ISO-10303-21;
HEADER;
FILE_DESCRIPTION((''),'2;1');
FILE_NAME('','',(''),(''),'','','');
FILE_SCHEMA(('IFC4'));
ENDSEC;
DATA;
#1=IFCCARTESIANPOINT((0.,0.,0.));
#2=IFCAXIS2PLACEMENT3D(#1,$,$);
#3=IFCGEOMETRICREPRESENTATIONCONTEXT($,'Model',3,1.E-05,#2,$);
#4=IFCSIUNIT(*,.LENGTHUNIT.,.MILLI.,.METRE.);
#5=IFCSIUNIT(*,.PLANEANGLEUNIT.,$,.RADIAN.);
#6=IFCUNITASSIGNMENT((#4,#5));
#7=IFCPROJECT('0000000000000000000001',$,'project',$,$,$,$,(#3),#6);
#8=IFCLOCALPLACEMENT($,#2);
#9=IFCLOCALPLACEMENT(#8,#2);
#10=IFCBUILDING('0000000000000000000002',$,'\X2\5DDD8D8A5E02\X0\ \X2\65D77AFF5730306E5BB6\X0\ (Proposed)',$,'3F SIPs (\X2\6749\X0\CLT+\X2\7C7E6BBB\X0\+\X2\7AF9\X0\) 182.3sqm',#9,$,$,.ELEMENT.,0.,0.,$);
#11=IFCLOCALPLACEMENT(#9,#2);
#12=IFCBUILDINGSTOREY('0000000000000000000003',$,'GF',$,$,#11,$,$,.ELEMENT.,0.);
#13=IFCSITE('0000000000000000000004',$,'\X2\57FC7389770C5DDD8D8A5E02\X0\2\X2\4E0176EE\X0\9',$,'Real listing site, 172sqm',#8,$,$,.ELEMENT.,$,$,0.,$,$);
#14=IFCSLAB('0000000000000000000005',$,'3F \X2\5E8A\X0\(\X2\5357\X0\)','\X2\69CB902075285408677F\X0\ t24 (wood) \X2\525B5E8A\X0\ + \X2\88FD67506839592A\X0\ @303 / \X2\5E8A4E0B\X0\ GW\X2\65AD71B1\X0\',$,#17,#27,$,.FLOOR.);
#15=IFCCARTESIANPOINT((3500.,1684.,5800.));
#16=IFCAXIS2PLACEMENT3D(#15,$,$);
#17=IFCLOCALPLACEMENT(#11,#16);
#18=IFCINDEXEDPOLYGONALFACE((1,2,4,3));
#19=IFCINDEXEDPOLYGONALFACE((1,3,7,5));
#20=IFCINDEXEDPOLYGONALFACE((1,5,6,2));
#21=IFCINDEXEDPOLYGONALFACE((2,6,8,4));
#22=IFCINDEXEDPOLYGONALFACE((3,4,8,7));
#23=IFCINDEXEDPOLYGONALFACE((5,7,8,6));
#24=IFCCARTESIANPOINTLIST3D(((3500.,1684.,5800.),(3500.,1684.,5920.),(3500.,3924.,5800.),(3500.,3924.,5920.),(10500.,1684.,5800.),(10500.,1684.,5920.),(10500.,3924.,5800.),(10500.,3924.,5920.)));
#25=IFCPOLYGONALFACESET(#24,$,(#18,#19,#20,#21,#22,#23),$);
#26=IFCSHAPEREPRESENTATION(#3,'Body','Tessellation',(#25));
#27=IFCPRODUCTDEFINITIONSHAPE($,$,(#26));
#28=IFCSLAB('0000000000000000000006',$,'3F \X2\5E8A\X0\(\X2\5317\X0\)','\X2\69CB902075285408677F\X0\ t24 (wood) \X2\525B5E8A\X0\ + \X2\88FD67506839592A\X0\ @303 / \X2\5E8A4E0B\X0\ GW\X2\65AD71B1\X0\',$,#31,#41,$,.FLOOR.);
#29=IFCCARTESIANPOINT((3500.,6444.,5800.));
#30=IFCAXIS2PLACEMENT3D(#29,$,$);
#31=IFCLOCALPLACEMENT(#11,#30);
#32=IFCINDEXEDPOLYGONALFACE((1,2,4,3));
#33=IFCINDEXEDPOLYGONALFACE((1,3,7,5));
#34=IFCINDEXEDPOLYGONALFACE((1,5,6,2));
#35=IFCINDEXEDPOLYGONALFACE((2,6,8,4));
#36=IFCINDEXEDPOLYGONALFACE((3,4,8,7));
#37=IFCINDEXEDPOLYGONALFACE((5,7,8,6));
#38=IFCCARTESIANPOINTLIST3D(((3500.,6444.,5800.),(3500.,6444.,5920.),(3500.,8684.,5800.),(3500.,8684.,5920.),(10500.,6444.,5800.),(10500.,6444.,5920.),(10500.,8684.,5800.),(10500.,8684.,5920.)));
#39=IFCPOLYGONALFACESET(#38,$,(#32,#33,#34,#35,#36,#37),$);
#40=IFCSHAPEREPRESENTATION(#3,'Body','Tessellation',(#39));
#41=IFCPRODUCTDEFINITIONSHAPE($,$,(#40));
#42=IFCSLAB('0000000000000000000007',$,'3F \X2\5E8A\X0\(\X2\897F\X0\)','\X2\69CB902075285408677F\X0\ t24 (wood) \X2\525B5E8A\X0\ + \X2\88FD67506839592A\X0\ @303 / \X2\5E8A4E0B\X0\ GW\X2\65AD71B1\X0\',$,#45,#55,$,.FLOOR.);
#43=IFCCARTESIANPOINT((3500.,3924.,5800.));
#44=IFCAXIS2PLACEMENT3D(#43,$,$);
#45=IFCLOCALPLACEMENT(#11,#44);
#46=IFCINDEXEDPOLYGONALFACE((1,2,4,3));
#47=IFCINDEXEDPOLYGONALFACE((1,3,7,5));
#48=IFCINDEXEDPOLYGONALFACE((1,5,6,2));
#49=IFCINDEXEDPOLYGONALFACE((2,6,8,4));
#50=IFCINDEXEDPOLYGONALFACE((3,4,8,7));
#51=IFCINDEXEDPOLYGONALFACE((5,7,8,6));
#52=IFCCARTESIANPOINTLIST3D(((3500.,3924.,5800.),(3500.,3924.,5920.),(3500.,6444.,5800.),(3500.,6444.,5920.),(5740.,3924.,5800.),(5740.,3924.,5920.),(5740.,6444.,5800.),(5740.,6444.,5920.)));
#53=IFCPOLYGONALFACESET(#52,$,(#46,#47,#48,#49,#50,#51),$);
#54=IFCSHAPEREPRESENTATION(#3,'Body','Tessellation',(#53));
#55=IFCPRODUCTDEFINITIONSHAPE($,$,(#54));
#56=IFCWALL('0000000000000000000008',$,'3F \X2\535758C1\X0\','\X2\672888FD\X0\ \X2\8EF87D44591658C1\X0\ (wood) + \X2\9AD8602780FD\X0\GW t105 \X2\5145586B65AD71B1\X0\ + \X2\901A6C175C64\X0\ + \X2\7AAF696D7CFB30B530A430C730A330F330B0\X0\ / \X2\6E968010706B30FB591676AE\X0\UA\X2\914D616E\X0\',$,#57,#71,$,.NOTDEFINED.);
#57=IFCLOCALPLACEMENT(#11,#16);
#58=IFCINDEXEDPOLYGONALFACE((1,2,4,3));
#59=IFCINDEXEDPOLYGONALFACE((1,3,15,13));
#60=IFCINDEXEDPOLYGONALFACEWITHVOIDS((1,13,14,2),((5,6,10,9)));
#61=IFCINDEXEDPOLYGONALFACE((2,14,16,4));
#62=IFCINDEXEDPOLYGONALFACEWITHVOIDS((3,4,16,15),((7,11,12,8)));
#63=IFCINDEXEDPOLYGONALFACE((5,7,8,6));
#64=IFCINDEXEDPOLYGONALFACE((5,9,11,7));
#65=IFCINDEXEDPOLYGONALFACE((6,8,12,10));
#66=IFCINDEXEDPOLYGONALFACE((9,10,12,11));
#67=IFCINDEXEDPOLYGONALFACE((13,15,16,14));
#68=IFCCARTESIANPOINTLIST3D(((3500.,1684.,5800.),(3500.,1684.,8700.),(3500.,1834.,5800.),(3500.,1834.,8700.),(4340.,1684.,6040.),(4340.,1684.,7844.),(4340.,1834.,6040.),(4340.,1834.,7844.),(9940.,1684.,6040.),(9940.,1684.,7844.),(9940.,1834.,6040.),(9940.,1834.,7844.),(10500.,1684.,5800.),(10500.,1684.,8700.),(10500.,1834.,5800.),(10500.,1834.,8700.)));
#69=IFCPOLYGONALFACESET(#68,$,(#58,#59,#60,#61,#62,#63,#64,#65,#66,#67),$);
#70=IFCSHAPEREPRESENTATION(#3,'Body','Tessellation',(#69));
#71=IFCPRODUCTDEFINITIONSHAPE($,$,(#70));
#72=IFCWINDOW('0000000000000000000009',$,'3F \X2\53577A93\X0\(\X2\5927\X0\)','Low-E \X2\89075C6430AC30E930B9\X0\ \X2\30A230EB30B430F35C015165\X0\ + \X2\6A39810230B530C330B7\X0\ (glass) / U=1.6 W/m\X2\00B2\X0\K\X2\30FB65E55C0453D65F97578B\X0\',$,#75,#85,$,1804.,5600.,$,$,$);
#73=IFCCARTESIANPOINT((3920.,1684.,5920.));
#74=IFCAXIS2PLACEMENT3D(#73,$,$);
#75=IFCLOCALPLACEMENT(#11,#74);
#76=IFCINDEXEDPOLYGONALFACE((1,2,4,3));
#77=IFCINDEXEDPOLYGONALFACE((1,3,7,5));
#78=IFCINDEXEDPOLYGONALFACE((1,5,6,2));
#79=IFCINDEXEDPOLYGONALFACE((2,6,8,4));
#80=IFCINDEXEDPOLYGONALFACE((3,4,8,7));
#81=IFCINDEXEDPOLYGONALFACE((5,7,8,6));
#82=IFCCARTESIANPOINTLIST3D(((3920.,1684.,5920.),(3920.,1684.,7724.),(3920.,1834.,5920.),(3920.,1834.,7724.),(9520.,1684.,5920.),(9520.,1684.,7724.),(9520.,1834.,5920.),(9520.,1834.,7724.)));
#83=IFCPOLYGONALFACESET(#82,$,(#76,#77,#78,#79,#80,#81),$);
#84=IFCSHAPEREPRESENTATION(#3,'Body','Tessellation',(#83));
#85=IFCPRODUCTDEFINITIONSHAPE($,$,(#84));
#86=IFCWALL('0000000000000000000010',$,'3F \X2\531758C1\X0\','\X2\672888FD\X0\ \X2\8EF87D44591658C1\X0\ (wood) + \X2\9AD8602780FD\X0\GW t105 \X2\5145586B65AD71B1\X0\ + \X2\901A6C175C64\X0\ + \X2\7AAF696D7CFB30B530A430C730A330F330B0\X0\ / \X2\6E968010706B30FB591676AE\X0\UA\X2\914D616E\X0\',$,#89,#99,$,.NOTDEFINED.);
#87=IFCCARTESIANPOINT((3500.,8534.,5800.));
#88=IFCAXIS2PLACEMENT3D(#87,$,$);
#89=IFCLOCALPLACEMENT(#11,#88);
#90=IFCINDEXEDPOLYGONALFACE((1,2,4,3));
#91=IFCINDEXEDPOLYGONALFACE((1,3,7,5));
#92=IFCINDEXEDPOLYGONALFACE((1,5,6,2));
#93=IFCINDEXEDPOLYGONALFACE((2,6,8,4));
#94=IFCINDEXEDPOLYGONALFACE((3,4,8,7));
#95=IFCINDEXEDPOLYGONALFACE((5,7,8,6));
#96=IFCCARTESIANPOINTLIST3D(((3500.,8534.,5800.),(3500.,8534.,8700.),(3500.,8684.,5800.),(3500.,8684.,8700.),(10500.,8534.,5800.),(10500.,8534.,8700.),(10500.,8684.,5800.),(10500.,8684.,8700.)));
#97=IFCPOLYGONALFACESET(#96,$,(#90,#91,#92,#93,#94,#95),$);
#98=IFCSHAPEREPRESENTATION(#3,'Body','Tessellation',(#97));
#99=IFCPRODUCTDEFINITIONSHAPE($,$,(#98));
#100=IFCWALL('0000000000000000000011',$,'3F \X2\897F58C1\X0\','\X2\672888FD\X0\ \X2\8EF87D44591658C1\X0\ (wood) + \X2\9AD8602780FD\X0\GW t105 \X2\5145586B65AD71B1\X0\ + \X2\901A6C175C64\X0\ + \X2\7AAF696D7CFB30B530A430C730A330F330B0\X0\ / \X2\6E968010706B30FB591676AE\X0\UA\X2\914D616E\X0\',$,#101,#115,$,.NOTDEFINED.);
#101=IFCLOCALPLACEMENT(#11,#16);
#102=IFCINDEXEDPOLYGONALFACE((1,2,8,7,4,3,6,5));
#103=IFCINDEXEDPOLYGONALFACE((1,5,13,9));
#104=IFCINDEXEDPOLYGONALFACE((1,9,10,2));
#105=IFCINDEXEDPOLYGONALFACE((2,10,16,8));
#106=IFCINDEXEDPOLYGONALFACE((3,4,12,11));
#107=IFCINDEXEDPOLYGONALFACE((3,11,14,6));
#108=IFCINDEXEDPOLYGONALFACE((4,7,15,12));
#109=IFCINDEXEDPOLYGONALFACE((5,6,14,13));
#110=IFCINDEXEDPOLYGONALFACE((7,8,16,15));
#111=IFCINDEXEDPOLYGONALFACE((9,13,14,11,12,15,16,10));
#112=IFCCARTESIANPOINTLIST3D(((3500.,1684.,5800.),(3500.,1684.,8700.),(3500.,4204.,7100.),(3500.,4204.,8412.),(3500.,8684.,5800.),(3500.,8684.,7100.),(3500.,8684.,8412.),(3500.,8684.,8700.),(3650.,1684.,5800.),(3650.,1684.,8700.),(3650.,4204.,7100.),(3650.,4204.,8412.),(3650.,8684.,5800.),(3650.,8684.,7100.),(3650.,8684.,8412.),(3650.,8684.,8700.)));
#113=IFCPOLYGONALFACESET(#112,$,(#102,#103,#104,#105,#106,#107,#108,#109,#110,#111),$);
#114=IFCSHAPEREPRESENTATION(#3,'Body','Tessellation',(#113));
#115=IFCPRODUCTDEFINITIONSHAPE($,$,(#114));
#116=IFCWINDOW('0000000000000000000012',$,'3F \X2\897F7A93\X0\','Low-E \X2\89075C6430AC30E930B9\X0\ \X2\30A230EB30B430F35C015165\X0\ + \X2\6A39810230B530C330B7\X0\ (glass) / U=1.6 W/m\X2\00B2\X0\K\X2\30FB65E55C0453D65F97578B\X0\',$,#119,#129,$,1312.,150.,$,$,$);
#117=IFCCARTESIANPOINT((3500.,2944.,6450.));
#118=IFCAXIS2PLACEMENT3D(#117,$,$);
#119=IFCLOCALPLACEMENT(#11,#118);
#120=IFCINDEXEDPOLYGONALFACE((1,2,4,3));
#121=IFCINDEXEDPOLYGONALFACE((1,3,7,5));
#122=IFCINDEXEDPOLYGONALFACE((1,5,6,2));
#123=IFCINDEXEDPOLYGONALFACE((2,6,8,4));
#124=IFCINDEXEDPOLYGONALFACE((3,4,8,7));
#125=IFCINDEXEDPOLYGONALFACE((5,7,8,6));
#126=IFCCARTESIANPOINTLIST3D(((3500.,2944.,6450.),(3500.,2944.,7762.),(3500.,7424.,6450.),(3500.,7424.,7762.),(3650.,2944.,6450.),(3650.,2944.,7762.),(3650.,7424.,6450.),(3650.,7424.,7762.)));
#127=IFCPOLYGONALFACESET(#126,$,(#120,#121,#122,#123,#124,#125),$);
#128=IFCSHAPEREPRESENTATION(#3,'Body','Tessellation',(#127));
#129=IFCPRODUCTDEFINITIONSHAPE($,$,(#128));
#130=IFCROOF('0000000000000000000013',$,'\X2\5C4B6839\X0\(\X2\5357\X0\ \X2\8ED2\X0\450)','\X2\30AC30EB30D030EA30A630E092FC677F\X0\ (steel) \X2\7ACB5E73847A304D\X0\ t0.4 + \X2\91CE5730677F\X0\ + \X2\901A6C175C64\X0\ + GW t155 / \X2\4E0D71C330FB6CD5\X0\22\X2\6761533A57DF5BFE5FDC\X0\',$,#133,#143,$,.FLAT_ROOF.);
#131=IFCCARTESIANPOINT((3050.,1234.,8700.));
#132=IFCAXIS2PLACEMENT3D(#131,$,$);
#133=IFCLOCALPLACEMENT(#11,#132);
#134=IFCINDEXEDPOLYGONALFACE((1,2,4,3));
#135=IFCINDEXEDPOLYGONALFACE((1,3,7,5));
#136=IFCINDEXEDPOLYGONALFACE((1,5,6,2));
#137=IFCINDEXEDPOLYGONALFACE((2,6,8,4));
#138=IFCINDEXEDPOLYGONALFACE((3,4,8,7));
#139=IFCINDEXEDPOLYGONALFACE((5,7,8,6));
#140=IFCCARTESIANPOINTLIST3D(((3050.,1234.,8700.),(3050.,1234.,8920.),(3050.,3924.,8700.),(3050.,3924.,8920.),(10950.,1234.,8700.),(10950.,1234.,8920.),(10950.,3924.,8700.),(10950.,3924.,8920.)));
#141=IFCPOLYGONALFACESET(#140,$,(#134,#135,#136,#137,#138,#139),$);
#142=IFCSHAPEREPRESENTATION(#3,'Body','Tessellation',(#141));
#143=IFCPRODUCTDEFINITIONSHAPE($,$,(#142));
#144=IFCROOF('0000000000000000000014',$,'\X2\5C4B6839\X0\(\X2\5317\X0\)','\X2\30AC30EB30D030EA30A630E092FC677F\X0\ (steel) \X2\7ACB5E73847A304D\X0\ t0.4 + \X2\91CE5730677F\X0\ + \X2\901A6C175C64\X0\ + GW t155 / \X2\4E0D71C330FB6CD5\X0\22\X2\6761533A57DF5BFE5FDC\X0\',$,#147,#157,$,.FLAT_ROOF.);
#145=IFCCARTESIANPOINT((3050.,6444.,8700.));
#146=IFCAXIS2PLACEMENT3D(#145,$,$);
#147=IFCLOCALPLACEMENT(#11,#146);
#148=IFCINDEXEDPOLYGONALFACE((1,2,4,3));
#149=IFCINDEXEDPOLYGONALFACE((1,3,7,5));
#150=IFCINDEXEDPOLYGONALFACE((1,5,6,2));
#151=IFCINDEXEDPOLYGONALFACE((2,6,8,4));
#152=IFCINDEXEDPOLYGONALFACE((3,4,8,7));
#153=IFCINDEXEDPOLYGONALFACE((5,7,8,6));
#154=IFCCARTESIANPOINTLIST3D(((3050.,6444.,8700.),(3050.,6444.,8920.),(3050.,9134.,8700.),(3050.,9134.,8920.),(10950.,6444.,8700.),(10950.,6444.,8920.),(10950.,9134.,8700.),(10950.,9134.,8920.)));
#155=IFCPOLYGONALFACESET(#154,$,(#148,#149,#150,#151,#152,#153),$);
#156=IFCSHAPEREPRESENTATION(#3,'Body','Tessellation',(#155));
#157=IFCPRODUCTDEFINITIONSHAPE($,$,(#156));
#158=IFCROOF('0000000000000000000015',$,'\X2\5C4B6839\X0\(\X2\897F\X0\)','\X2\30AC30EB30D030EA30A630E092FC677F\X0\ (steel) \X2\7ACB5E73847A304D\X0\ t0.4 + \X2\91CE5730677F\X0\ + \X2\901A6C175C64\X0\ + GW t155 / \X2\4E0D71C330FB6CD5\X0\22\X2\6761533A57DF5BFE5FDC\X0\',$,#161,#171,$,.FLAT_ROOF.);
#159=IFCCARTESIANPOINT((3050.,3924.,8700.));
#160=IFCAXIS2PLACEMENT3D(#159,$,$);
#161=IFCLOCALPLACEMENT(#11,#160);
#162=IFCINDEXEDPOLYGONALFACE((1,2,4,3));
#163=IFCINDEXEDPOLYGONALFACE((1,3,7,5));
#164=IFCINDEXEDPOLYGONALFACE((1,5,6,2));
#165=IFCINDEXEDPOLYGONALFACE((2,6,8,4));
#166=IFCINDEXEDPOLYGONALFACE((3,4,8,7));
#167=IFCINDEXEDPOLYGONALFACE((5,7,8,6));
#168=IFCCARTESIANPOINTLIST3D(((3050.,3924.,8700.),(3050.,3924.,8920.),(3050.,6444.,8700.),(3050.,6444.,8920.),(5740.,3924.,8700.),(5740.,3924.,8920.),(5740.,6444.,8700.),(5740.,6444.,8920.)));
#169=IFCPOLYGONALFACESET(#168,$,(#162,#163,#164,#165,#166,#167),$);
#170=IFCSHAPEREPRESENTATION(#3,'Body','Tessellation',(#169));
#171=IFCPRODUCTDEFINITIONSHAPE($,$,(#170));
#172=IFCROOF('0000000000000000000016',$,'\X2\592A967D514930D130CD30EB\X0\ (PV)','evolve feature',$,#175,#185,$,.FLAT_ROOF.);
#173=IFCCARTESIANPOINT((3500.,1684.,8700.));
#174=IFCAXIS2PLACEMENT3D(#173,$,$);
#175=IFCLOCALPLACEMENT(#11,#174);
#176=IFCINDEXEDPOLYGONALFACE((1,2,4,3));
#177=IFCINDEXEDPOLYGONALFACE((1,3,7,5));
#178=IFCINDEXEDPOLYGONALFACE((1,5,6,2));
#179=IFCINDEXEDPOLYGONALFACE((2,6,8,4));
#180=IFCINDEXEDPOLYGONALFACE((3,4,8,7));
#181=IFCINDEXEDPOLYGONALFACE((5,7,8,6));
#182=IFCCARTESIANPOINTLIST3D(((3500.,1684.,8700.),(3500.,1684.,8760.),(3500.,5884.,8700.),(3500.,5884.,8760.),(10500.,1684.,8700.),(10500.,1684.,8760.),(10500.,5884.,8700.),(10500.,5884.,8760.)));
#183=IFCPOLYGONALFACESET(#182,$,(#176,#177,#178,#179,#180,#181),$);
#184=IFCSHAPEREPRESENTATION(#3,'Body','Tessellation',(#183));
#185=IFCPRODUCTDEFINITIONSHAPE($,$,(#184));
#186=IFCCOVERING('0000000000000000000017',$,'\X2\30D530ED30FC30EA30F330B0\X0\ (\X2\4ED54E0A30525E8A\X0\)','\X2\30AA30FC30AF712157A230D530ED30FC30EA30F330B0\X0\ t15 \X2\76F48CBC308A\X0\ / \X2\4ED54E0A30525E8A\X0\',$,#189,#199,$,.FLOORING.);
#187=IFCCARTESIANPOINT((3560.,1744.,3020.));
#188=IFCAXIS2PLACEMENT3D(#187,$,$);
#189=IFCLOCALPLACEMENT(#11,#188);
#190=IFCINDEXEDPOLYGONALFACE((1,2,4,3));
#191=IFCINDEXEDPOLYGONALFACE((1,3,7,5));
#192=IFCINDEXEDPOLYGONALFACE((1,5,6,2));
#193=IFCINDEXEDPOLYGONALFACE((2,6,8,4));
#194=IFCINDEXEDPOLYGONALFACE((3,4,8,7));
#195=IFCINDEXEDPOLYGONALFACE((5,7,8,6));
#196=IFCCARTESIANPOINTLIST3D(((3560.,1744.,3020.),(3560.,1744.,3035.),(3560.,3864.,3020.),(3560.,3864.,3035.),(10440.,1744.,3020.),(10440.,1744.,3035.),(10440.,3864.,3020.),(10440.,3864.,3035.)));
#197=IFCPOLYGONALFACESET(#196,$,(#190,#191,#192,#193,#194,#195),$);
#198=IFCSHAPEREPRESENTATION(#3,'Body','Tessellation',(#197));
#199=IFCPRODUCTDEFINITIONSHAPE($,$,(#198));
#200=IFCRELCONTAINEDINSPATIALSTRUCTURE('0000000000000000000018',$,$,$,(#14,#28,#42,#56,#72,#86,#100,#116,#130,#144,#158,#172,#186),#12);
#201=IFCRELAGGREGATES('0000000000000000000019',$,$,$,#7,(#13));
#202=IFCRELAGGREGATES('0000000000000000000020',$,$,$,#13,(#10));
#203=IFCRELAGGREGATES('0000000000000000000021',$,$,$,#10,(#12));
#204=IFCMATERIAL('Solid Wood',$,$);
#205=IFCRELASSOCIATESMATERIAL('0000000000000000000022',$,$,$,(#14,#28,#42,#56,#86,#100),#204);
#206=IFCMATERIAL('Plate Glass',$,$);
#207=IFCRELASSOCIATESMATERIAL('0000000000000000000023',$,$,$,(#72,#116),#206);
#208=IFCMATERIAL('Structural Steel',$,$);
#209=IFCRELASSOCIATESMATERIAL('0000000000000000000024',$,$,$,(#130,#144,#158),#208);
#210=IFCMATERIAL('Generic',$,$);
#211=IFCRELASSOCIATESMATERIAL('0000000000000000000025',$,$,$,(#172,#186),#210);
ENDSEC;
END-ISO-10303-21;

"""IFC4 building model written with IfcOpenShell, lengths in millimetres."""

from ifc_helpers import new_model, si_unit, frame, frame_2d, origin, place, context, project, spatial, rectangle, extrude, material, element, fill, save


model = new_model("IFC4")

# Units and contexts
model_context = context("Model", 3, precision=1e-05, world=origin())
ifc_project = project(units=[si_unit("LENGTHUNIT", "METRE", prefix="MILLI"), si_unit("PLANEANGLEUNIT", "RADIAN")], contexts=[model_context])

# Site, building, storey
site_placement = place(None, origin())
site = spatial("IfcSite", under=ifc_project, at=site_placement, Name="埼玉県川越市2丁目9", ObjectType="Real listing site, 172sqm", CompositionType="ELEMENT", RefElevation=0.0)
building_placement = place(site_placement, origin())
building = spatial("IfcBuilding", under=site, at=building_placement, Name="川越市 旗竿地の家 (Proposed)", ObjectType="3F SIPs (杉CLT+籾殻+竹) 182.3sqm", CompositionType="ELEMENT", ElevationOfRefHeight=0.0, ElevationOfTerrain=0.0)
storey_placement = place(building_placement, origin())
storey = spatial("IfcBuildingStorey", under=building, at=storey_placement, Name="GF", CompositionType="ELEMENT", Elevation=0.0)

# Slabs
ifc_material_1 = material(Name="Solid Wood")
slab_1_placement = place(storey_placement, frame((3500.0, 1684.0, 5800.0)))
element("IfcSlab", 1, at=slab_1_placement, inside=storey, material=ifc_material_1, Name="3F 床(南)", Description="構造用合板 t24 (wood) 剛床 + 製材根太 @303 / 床下 GW断熱", PredefinedType="FLOOR", context=model_context, shape_type="SweptSolid", body=[
    extrude(rectangle(XDim=7000.0, YDim=2240.0, at=frame_2d((3500.0, 1120.0))), frame((3500.0, 1684.0, 5800.0)), (0.0, 0.0, 1.0), 120.0),
])
slab_2_placement = place(storey_placement, frame((3500.0, 6444.0, 5800.0)))
element("IfcSlab", 2, at=slab_2_placement, inside=storey, material=ifc_material_1, Name="3F 床(北)", Description="構造用合板 t24 (wood) 剛床 + 製材根太 @303 / 床下 GW断熱", PredefinedType="FLOOR", context=model_context, shape_type="SweptSolid", body=[
    extrude(rectangle(XDim=7000.0, YDim=2240.0, at=frame_2d((3500.0, 1120.0))), frame((3500.0, 6444.0, 5800.0)), (0.0, 0.0, 1.0), 120.0),
])
slab_3_placement = place(storey_placement, frame((3500.0, 3924.0, 5800.0)))
element("IfcSlab", 3, at=slab_3_placement, inside=storey, material=ifc_material_1, Name="3F 床(西)", Description="構造用合板 t24 (wood) 剛床 + 製材根太 @303 / 床下 GW断熱", PredefinedType="FLOOR", context=model_context, shape_type="SweptSolid", body=[
    extrude(rectangle(XDim=2240.0, YDim=2520.0, at=frame_2d((1120.0, 1260.0))), frame((3500.0, 3924.0, 5800.0)), (0.0, 0.0, 1.0), 120.0),
])

# Wall, opening, window
wall_1_placement = place(storey_placement, frame((3500.0, 1684.0, 5800.0)))
wall_1 = element("IfcWall", 4, at=wall_1_placement, inside=storey, material=ifc_material_1, Name="3F 南壁", Description="木製 軸組外壁 (wood) + 高性能GW t105 充填断熱 + 通気層 + 窯業系サイディング / 準耐火・外皮UA配慮", PredefinedType="NOTDEFINED", context=model_context, shape_type="SweptSolid", body=[
    extrude(rectangle(XDim=7000.0, YDim=150.0, at=frame_2d((3500.0, 75.0))), frame((3500.0, 1684.0, 5800.0)), (0.0, 0.0, 1.0), 2900.0),
])
opening_1_placement = place(storey_placement, frame((3920.0, 1684.0, 5920.0)))
opening_1 = element("IfcOpeningElement", 5, at=opening_1_placement, cuts=wall_1, PredefinedType="NOTDEFINED", context=model_context, shape_type="SweptSolid", body=[
    extrude(rectangle(XDim=5600.0, YDim=150.0, at=frame_2d((2800.0, 75.0))), frame((3920.0, 1684.0, 5920.0)), (0.0, 0.0, 1.0), 1804.0),
])
ifc_material_2 = material(Name="Plate Glass")
window_1_placement = place(storey_placement, frame((3920.0, 1684.0, 5920.0)))
window_1 = element("IfcWindow", 6, at=window_1_placement, inside=storey, material=ifc_material_2, Name="3F 南窓(大)", Description="Low-E 複層ガラス アルゴン封入 + 樹脂サッシ (glass) / U=1.6 W/m²K・日射取得型", OverallHeight=1804.0, OverallWidth=5600.0, context=model_context, shape_type="SweptSolid", body=[
    extrude(rectangle(XDim=5600.0, YDim=150.0, at=frame_2d((2800.0, 75.0))), frame((3920.0, 1684.0, 5920.0)), (0.0, 0.0, 1.0), 1804.0),
])
fill(opening_1, window_1)

# Wall
wall_2_placement = place(storey_placement, frame((3500.0, 8534.0, 5800.0)))
element("IfcWall", 7, at=wall_2_placement, inside=storey, material=ifc_material_1, Name="3F 北壁", Description="木製 軸組外壁 (wood) + 高性能GW t105 充填断熱 + 通気層 + 窯業系サイディング / 準耐火・外皮UA配慮", PredefinedType="NOTDEFINED", context=model_context, shape_type="SweptSolid", body=[
    extrude(rectangle(XDim=7000.0, YDim=150.0, at=frame_2d((3500.0, 75.0))), frame((3500.0, 8534.0, 5800.0)), (0.0, 0.0, 1.0), 2900.0),
])

# Wall, opening, window
wall_3_placement = place(storey_placement, frame((3500.0, 1684.0, 5800.0)))
wall_3 = element("IfcWall", 8, at=wall_3_placement, inside=storey, material=ifc_material_1, Name="3F 西壁", Description="木製 軸組外壁 (wood) + 高性能GW t105 充填断熱 + 通気層 + 窯業系サイディング / 準耐火・外皮UA配慮", PredefinedType="NOTDEFINED", context=model_context, shape_type="SweptSolid", body=[
    extrude(rectangle(XDim=150.0, YDim=7000.0, at=frame_2d((75.0, 3500.0))), frame((3500.0, 1684.0, 5800.0)), (0.0, 0.0, 1.0), 2900.0),
])
opening_2_placement = place(storey_placement, frame((3500.0, 2944.0, 6450.0)))
opening_2 = element("IfcOpeningElement", 9, at=opening_2_placement, cuts=wall_3, PredefinedType="NOTDEFINED", context=model_context, shape_type="SweptSolid", body=[
    extrude(rectangle(XDim=150.0, YDim=4480.0, at=frame_2d((75.0, 2240.0))), frame((3500.0, 2944.0, 6450.0)), (0.0, 0.0, 1.0), 1312.0),
])
window_2_placement = place(storey_placement, frame((3500.0, 2944.0, 6450.0)))
window_2 = element("IfcWindow", 10, at=window_2_placement, inside=storey, material=ifc_material_2, Name="3F 西窓", Description="Low-E 複層ガラス アルゴン封入 + 樹脂サッシ (glass) / U=1.6 W/m²K・日射取得型", OverallHeight=1312.0, OverallWidth=150.0, context=model_context, shape_type="SweptSolid", body=[
    extrude(rectangle(XDim=150.0, YDim=4480.0, at=frame_2d((75.0, 2240.0))), frame((3500.0, 2944.0, 6450.0)), (0.0, 0.0, 1.0), 1312.0),
])
fill(opening_2, window_2)

# Roofs
ifc_material_3 = material(Name="Structural Steel")
roof_1_placement = place(storey_placement, frame((3050.0, 1234.0, 8700.0)))
element("IfcRoof", 11, at=roof_1_placement, inside=storey, material=ifc_material_3, Name="屋根(南 軒450)", Description="ガルバリウム鋼板 (steel) 立平葺き t0.4 + 野地板 + 通気層 + GW t155 / 不燃・法22条区域対応", PredefinedType="FLAT_ROOF", context=model_context, shape_type="SweptSolid", body=[
    extrude(rectangle(XDim=7900.0, YDim=2690.0, at=frame_2d((3950.0, 1345.0))), frame((3050.0, 1234.0, 8700.0)), (0.0, 0.0, 1.0), 220.0),
])
roof_2_placement = place(storey_placement, frame((3050.0, 6444.0, 8700.0)))
element("IfcRoof", 12, at=roof_2_placement, inside=storey, material=ifc_material_3, Name="屋根(北)", Description="ガルバリウム鋼板 (steel) 立平葺き t0.4 + 野地板 + 通気層 + GW t155 / 不燃・法22条区域対応", PredefinedType="FLAT_ROOF", context=model_context, shape_type="SweptSolid", body=[
    extrude(rectangle(XDim=7900.0, YDim=2690.0, at=frame_2d((3950.0, 1345.0))), frame((3050.0, 6444.0, 8700.0)), (0.0, 0.0, 1.0), 220.0),
])
roof_3_placement = place(storey_placement, frame((3050.0, 3924.0, 8700.0)))
element("IfcRoof", 13, at=roof_3_placement, inside=storey, material=ifc_material_3, Name="屋根(西)", Description="ガルバリウム鋼板 (steel) 立平葺き t0.4 + 野地板 + 通気層 + GW t155 / 不燃・法22条区域対応", PredefinedType="FLAT_ROOF", context=model_context, shape_type="SweptSolid", body=[
    extrude(rectangle(XDim=2690.0, YDim=2520.0, at=frame_2d((1345.0, 1260.0))), frame((3050.0, 3924.0, 8700.0)), (0.0, 0.0, 1.0), 220.0),
])
ifc_material_4 = material(Name="Generic")
roof_4_placement = place(storey_placement, frame((3500.0, 1684.0, 8700.0)))
element("IfcRoof", 14, at=roof_4_placement, inside=storey, material=ifc_material_4, Name="太陽光パネル (PV)", Description="evolve feature", PredefinedType="FLAT_ROOF", context=model_context, shape_type="SweptSolid", body=[
    extrude(rectangle(XDim=7000.0, YDim=4200.0, at=frame_2d((3500.0, 2100.0))), frame((3500.0, 1684.0, 8700.0)), (0.0, 0.0, 1.0), 60.0),
])

# Covering
covering_1_placement = place(storey_placement, frame((3560.0, 1744.0, 3020.0)))
element("IfcCovering", 15, at=covering_1_placement, inside=storey, material=ifc_material_4, Name="フローリング (仕上げ床)", Description="オーク無垢フローリング t15 直貼り / 仕上げ床", PredefinedType="FLOORING", context=model_context, shape_type="SweptSolid", body=[
    extrude(rectangle(XDim=6880.0, YDim=2120.0, at=frame_2d((3440.0, 1060.0))), frame((3560.0, 1744.0, 3020.0)), (0.0, 0.0, 1.0), 15.0),
])

save(model, "model.ifc")
